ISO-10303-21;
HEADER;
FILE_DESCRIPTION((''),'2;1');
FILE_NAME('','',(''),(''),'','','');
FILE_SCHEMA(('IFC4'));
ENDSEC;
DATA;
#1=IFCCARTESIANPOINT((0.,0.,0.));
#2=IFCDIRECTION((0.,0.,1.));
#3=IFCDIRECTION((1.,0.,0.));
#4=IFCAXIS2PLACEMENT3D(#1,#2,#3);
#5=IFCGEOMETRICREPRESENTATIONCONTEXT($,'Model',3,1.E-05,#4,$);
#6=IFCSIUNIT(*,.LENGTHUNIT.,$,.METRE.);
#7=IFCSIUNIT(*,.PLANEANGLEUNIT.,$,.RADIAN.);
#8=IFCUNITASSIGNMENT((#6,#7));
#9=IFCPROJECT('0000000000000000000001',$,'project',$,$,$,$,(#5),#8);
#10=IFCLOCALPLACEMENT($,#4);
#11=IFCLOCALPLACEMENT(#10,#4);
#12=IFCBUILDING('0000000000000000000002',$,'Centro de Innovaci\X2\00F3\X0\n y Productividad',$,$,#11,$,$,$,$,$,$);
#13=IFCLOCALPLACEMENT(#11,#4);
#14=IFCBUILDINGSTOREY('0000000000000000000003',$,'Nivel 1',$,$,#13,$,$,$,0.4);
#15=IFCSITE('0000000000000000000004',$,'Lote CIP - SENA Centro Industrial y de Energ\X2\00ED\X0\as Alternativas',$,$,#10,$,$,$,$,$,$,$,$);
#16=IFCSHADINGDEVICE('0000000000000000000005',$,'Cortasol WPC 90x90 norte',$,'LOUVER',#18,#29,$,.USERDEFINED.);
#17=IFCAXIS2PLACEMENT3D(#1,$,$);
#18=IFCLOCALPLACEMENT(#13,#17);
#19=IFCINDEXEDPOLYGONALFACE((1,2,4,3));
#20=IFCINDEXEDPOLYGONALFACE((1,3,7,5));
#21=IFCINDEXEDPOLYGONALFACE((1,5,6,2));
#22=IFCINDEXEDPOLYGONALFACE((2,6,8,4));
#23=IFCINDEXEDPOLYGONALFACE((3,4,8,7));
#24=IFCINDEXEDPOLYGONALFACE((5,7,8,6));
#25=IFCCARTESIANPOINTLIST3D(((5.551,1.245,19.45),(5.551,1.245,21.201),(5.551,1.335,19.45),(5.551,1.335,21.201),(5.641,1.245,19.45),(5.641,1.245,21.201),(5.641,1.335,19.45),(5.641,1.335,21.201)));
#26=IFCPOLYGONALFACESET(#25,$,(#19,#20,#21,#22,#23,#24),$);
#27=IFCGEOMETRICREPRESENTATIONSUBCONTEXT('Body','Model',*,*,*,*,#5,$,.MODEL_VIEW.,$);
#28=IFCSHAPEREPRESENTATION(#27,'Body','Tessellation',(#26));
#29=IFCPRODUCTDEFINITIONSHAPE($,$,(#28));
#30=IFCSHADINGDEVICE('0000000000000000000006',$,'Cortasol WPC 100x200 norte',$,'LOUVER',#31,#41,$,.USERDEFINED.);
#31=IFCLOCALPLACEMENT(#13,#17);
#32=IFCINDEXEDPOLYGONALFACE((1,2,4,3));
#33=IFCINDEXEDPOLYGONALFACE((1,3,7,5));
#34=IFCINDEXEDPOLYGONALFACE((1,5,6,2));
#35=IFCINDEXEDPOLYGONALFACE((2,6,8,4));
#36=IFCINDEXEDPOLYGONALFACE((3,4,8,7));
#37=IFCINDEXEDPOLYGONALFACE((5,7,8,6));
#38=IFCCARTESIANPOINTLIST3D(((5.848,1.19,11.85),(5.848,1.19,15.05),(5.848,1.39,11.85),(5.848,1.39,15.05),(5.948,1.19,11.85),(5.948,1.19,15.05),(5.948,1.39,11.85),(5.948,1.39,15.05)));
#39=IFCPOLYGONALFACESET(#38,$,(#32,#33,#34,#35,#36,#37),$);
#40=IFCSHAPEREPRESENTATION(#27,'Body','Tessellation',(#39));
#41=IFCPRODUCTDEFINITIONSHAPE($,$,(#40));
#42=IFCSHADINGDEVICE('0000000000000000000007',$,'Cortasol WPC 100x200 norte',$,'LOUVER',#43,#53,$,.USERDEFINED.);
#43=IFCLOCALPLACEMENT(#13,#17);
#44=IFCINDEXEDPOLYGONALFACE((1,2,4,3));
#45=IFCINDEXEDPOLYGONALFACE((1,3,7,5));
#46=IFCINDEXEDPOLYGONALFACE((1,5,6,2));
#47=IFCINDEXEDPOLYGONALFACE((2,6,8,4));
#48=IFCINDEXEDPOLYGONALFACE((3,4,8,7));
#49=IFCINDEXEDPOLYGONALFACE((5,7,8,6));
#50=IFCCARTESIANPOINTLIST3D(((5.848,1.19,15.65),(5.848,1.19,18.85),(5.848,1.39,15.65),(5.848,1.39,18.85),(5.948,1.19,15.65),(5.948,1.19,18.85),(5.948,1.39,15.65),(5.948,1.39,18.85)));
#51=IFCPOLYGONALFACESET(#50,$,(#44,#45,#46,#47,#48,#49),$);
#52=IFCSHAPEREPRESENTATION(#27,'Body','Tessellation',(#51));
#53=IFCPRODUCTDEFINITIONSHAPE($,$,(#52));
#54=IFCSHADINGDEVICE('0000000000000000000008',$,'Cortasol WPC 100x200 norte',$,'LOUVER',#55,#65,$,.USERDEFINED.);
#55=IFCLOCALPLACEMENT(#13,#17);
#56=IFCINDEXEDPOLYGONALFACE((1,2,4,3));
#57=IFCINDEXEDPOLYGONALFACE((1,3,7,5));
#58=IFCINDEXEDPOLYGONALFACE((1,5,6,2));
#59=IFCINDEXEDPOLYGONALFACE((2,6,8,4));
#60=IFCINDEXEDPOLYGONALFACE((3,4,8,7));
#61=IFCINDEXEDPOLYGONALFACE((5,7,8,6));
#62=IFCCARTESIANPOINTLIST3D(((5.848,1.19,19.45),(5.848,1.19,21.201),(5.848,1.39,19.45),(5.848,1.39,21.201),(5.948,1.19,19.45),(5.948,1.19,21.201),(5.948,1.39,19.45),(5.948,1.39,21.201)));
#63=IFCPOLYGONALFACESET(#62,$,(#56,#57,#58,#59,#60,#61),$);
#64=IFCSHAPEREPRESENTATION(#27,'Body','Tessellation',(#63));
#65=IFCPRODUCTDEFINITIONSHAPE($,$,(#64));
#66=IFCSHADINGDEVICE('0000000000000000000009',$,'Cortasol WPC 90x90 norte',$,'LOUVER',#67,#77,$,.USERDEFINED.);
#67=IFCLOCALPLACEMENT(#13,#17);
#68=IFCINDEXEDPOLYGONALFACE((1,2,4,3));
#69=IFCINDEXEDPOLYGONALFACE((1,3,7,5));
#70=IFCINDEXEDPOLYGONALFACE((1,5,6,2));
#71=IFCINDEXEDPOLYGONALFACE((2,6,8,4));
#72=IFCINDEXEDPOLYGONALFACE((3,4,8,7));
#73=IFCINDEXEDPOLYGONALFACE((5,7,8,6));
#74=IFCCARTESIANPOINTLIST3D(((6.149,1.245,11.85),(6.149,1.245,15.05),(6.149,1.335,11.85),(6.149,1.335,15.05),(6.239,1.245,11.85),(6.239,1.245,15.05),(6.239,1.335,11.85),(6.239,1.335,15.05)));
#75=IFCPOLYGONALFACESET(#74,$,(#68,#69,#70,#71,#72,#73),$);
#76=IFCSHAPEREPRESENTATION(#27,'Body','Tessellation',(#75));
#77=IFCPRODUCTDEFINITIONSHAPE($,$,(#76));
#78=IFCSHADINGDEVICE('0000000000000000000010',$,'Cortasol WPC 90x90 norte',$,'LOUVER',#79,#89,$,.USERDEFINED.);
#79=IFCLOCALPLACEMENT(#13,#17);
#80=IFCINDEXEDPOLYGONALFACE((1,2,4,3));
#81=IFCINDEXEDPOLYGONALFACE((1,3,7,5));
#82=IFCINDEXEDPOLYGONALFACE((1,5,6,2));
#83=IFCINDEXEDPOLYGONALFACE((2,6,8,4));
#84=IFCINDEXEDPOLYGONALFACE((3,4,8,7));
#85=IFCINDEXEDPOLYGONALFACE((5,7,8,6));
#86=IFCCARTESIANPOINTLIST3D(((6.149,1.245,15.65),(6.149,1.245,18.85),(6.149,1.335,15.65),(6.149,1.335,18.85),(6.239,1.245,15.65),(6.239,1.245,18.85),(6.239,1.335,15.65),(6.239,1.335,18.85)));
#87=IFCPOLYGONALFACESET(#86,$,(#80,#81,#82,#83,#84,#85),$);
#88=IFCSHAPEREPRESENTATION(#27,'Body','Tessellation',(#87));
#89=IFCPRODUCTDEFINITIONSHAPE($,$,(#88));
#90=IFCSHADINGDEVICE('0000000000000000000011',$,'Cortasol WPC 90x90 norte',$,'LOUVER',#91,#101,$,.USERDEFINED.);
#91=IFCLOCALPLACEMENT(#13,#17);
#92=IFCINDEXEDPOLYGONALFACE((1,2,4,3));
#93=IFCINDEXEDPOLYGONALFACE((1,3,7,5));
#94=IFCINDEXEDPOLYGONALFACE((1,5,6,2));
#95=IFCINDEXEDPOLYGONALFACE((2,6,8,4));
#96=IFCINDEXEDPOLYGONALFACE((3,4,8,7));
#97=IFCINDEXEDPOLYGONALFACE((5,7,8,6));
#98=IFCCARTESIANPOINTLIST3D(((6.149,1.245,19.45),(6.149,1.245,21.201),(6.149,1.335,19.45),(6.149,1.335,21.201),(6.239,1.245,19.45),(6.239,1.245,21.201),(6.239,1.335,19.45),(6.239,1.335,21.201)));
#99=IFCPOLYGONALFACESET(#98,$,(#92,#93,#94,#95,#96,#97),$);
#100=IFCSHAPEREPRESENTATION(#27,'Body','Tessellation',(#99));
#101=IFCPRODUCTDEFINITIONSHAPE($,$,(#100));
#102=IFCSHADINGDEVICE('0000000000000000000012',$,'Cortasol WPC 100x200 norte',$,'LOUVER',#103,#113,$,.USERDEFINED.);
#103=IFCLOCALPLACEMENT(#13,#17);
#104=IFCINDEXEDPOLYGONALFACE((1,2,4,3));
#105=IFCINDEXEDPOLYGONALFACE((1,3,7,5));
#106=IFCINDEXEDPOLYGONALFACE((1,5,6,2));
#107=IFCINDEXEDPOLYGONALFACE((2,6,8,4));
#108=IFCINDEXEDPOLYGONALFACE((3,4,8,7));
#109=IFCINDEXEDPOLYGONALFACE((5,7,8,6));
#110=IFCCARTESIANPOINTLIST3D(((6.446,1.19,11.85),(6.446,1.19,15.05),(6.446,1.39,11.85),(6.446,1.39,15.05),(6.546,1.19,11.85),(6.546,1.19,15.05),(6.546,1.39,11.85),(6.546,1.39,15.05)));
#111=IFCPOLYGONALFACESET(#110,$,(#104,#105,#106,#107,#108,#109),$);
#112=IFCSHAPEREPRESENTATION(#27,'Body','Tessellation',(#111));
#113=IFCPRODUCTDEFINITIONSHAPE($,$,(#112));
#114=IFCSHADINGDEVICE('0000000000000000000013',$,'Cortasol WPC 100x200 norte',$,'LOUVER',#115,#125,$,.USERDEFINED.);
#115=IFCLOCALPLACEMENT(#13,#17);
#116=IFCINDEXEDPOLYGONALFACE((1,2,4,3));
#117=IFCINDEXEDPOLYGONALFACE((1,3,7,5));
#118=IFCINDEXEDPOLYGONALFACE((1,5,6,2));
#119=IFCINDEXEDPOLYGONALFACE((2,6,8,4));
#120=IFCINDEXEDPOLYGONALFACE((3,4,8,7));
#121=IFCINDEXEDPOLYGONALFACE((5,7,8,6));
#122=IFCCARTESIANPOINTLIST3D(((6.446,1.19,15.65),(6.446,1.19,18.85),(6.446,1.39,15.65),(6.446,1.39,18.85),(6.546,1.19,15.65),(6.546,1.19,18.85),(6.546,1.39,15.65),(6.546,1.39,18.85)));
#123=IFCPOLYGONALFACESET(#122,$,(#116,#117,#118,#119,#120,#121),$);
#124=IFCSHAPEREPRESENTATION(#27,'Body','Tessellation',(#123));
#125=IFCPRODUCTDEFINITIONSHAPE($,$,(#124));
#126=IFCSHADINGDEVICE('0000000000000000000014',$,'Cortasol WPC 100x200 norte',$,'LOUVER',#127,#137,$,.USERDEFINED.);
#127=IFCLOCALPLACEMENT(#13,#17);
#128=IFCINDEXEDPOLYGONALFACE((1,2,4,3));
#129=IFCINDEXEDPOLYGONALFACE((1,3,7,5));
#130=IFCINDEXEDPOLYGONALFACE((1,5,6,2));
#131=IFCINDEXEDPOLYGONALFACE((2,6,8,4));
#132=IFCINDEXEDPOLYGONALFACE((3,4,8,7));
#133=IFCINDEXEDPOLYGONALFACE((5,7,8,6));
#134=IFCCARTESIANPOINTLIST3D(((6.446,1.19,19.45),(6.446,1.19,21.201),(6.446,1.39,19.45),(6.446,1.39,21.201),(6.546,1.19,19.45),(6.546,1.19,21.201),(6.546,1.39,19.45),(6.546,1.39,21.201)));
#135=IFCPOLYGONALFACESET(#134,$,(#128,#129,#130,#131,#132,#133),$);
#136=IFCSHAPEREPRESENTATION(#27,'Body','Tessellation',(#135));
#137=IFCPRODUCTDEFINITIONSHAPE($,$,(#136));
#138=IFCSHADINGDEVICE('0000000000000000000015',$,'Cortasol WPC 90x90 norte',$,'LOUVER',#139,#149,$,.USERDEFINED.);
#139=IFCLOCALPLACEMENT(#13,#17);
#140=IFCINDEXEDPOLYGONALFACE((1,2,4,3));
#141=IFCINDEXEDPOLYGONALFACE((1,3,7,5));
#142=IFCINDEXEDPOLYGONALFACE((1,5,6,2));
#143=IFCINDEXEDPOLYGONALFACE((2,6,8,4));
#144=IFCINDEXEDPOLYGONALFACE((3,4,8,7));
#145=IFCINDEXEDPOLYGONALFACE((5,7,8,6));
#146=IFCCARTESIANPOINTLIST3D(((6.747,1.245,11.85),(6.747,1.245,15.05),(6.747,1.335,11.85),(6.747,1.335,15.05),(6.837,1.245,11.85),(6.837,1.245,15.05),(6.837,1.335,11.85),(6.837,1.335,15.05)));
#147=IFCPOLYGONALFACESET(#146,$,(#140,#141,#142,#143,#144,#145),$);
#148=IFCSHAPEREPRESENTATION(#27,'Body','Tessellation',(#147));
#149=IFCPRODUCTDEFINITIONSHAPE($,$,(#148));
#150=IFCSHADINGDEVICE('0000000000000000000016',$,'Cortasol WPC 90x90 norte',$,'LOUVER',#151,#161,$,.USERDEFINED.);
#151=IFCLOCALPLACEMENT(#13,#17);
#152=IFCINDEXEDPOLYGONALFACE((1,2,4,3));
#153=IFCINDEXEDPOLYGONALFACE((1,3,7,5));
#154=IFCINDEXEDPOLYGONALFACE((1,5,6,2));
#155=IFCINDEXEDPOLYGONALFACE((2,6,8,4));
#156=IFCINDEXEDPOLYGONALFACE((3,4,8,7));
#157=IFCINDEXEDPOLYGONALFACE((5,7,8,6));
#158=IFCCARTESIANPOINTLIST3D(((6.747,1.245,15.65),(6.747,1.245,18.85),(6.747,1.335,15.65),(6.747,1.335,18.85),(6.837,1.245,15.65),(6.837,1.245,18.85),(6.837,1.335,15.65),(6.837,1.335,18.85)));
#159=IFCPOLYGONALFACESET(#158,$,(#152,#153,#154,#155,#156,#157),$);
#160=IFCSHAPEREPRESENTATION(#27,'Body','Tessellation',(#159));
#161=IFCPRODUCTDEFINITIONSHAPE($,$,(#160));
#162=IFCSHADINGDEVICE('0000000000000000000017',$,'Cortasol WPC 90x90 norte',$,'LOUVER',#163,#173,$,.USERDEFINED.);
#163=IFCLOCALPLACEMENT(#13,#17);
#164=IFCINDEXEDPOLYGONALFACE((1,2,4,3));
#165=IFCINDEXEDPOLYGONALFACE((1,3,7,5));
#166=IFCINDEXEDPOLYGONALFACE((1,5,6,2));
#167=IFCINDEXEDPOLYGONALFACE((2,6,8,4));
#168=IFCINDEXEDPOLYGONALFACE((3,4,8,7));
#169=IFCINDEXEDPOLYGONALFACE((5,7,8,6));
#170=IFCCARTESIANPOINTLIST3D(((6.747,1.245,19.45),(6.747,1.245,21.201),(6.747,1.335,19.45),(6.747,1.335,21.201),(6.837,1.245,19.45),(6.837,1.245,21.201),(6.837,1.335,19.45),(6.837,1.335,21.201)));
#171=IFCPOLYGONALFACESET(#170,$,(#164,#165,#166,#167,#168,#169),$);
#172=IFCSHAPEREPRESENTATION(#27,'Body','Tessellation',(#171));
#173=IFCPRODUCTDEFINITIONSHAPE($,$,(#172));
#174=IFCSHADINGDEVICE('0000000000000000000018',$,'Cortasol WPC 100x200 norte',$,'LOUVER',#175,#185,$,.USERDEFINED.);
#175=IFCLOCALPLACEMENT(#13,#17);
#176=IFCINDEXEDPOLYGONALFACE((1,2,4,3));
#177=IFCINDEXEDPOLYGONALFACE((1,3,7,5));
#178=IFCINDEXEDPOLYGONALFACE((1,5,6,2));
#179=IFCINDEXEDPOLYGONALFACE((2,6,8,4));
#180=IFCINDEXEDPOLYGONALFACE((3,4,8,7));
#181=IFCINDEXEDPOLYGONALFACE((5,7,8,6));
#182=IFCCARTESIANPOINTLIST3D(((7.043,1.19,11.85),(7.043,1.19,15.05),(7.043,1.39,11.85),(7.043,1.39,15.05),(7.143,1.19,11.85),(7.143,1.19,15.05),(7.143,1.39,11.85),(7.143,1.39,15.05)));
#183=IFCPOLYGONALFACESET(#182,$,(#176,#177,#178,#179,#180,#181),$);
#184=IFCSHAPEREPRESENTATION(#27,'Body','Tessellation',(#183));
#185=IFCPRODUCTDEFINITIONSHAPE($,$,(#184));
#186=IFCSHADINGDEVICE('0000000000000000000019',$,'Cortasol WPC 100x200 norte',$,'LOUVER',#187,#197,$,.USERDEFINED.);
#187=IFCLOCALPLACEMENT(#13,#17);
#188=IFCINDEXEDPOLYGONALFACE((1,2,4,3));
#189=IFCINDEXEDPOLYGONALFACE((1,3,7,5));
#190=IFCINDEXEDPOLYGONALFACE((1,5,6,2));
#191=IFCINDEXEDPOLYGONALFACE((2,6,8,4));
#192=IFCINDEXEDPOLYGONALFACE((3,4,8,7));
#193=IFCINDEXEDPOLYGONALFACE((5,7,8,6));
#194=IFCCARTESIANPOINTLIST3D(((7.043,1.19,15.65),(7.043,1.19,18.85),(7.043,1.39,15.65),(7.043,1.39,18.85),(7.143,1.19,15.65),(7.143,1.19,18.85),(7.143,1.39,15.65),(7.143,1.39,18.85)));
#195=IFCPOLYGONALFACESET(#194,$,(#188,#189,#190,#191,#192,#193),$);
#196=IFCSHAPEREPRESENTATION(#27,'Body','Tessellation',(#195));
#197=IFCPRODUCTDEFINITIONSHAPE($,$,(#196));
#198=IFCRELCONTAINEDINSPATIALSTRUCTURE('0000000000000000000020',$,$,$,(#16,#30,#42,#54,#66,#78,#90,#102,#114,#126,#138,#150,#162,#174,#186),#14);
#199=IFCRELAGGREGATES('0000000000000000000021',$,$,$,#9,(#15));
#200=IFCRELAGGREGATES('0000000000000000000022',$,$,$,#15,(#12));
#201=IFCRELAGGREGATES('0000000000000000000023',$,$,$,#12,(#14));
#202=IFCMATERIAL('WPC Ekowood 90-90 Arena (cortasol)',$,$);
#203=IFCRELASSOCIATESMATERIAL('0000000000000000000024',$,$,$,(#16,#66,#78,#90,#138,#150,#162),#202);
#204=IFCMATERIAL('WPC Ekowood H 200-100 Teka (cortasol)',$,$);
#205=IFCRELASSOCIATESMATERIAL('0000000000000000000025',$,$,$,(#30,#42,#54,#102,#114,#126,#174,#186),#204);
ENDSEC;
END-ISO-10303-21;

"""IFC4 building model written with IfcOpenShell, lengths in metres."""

from ifc_helpers import new_model, si_unit, frame, origin_with_axes, place, context, subcontext, project, spatial, polyline, outline, extrude, material, element, save


model = new_model("IFC4")

# Units and contexts
model_context = context("Model", 3, precision=1e-05, world=origin_with_axes())
body_context = subcontext(model_context, "Body", "Model", "MODEL_VIEW")
ifc_project = project(units=[si_unit("LENGTHUNIT", "METRE"), si_unit("PLANEANGLEUNIT", "RADIAN")], contexts=[model_context])

# Site, building, storey
site_placement = place(None, origin_with_axes())
site = spatial("IfcSite", under=ifc_project, at=site_placement, Name="Lote CIP - SENA Centro Industrial y de Energías Alternativas")
building_placement = place(site_placement, origin_with_axes())
building = spatial("IfcBuilding", under=site, at=building_placement, Name="Centro de Innovación y Productividad")
storey_placement = place(building_placement, origin_with_axes())
storey = spatial("IfcBuildingStorey", under=building, at=storey_placement, Name="Nivel 1", Elevation=0.4)

# Shading devices
ifc_material_1 = material(Name="WPC Ekowood 90-90 Arena (cortasol)")
shading_device_1_placement = place(storey_placement, origin_with_axes())
element("IfcShadingDevice", 1, at=shading_device_1_placement, inside=storey, material=ifc_material_1, Name="Cortasol WPC 90x90 norte", ObjectType="LOUVER", PredefinedType="USERDEFINED", context=body_context, shape_type="SweptSolid", body=[
    extrude(outline(polyline([(5.551, 1.245), (5.551, 1.335), (5.641, 1.335), (5.641, 1.245), (5.551, 1.245)])), frame((0.0, 0.0, 19.45)), (0.0, 0.0, 1.0), 1.751),
])
ifc_material_2 = material(Name="WPC Ekowood H 200-100 Teka (cortasol)")
shading_device_2_placement = place(storey_placement, origin_with_axes())
element("IfcShadingDevice", 2, at=shading_device_2_placement, inside=storey, material=ifc_material_2, Name="Cortasol WPC 100x200 norte", ObjectType="LOUVER", PredefinedType="USERDEFINED", context=body_context, shape_type="SweptSolid", body=[
    extrude(outline(polyline([(5.848, 1.19), (5.848, 1.39), (5.948, 1.39), (5.948, 1.19), (5.848, 1.19)])), frame((0.0, 0.0, 11.85)), (0.0, 0.0, 1.0), 3.2),
])
shading_device_3_placement = place(storey_placement, origin_with_axes())
element("IfcShadingDevice", 3, at=shading_device_3_placement, inside=storey, material=ifc_material_2, Name="Cortasol WPC 100x200 norte", ObjectType="LOUVER", PredefinedType="USERDEFINED", context=body_context, shape_type="SweptSolid", body=[
    extrude(outline(polyline([(5.848, 1.19), (5.848, 1.39), (5.948, 1.39), (5.948, 1.19), (5.848, 1.19)])), frame((0.0, 0.0, 15.65)), (0.0, 0.0, 1.0), 3.2),
])
shading_device_4_placement = place(storey_placement, origin_with_axes())
element("IfcShadingDevice", 4, at=shading_device_4_placement, inside=storey, material=ifc_material_2, Name="Cortasol WPC 100x200 norte", ObjectType="LOUVER", PredefinedType="USERDEFINED", context=body_context, shape_type="SweptSolid", body=[
    extrude(outline(polyline([(5.848, 1.19), (5.848, 1.39), (5.948, 1.39), (5.948, 1.19), (5.848, 1.19)])), frame((0.0, 0.0, 19.45)), (0.0, 0.0, 1.0), 1.751),
])
shading_device_5_placement = place(storey_placement, origin_with_axes())
element("IfcShadingDevice", 5, at=shading_device_5_placement, inside=storey, material=ifc_material_1, Name="Cortasol WPC 90x90 norte", ObjectType="LOUVER", PredefinedType="USERDEFINED", context=body_context, shape_type="SweptSolid", body=[
    extrude(outline(polyline([(6.149, 1.245), (6.149, 1.335), (6.239, 1.335), (6.239, 1.245), (6.149, 1.245)])), frame((0.0, 0.0, 11.85)), (0.0, 0.0, 1.0), 3.2),
])
shading_device_6_placement = place(storey_placement, origin_with_axes())
element("IfcShadingDevice", 6, at=shading_device_6_placement, inside=storey, material=ifc_material_1, Name="Cortasol WPC 90x90 norte", ObjectType="LOUVER", PredefinedType="USERDEFINED", context=body_context, shape_type="SweptSolid", body=[
    extrude(outline(polyline([(6.149, 1.245), (6.149, 1.335), (6.239, 1.335), (6.239, 1.245), (6.149, 1.245)])), frame((0.0, 0.0, 15.65)), (0.0, 0.0, 1.0), 3.2),
])
shading_device_7_placement = place(storey_placement, origin_with_axes())
element("IfcShadingDevice", 7, at=shading_device_7_placement, inside=storey, material=ifc_material_1, Name="Cortasol WPC 90x90 norte", ObjectType="LOUVER", PredefinedType="USERDEFINED", context=body_context, shape_type="SweptSolid", body=[
    extrude(outline(polyline([(6.149, 1.245), (6.149, 1.335), (6.239, 1.335), (6.239, 1.245), (6.149, 1.245)])), frame((0.0, 0.0, 19.45)), (0.0, 0.0, 1.0), 1.751),
])
shading_device_8_placement = place(storey_placement, origin_with_axes())
element("IfcShadingDevice", 8, at=shading_device_8_placement, inside=storey, material=ifc_material_2, Name="Cortasol WPC 100x200 norte", ObjectType="LOUVER", PredefinedType="USERDEFINED", context=body_context, shape_type="SweptSolid", body=[
    extrude(outline(polyline([(6.446, 1.19), (6.446, 1.39), (6.546, 1.39), (6.546, 1.19), (6.446, 1.19)])), frame((0.0, 0.0, 11.85)), (0.0, 0.0, 1.0), 3.2),
])
shading_device_9_placement = place(storey_placement, origin_with_axes())
element("IfcShadingDevice", 9, at=shading_device_9_placement, inside=storey, material=ifc_material_2, Name="Cortasol WPC 100x200 norte", ObjectType="LOUVER", PredefinedType="USERDEFINED", context=body_context, shape_type="SweptSolid", body=[
    extrude(outline(polyline([(6.446, 1.19), (6.446, 1.39), (6.546, 1.39), (6.546, 1.19), (6.446, 1.19)])), frame((0.0, 0.0, 15.65)), (0.0, 0.0, 1.0), 3.2),
])
shading_device_10_placement = place(storey_placement, origin_with_axes())
element("IfcShadingDevice", 10, at=shading_device_10_placement, inside=storey, material=ifc_material_2, Name="Cortasol WPC 100x200 norte", ObjectType="LOUVER", PredefinedType="USERDEFINED", context=body_context, shape_type="SweptSolid", body=[
    extrude(outline(polyline([(6.446, 1.19), (6.446, 1.39), (6.546, 1.39), (6.546, 1.19), (6.446, 1.19)])), frame((0.0, 0.0, 19.45)), (0.0, 0.0, 1.0), 1.751),
])
shading_device_11_placement = place(storey_placement, origin_with_axes())
element("IfcShadingDevice", 11, at=shading_device_11_placement, inside=storey, material=ifc_material_1, Name="Cortasol WPC 90x90 norte", ObjectType="LOUVER", PredefinedType="USERDEFINED", context=body_context, shape_type="SweptSolid", body=[
    extrude(outline(polyline([(6.747, 1.245), (6.747, 1.335), (6.837, 1.335), (6.837, 1.245), (6.747, 1.245)])), frame((0.0, 0.0, 11.85)), (0.0, 0.0, 1.0), 3.2),
])
shading_device_12_placement = place(storey_placement, origin_with_axes())
element("IfcShadingDevice", 12, at=shading_device_12_placement, inside=storey, material=ifc_material_1, Name="Cortasol WPC 90x90 norte", ObjectType="LOUVER", PredefinedType="USERDEFINED", context=body_context, shape_type="SweptSolid", body=[
    extrude(outline(polyline([(6.747, 1.245), (6.747, 1.335), (6.837, 1.335), (6.837, 1.245), (6.747, 1.245)])), frame((0.0, 0.0, 15.65)), (0.0, 0.0, 1.0), 3.2),
])
shading_device_13_placement = place(storey_placement, origin_with_axes())
element("IfcShadingDevice", 13, at=shading_device_13_placement, inside=storey, material=ifc_material_1, Name="Cortasol WPC 90x90 norte", ObjectType="LOUVER", PredefinedType="USERDEFINED", context=body_context, shape_type="SweptSolid", body=[
    extrude(outline(polyline([(6.747, 1.245), (6.747, 1.335), (6.837, 1.335), (6.837, 1.245), (6.747, 1.245)])), frame((0.0, 0.0, 19.45)), (0.0, 0.0, 1.0), 1.751),
])
shading_device_14_placement = place(storey_placement, origin_with_axes())
element("IfcShadingDevice", 14, at=shading_device_14_placement, inside=storey, material=ifc_material_2, Name="Cortasol WPC 100x200 norte", ObjectType="LOUVER", PredefinedType="USERDEFINED", context=body_context, shape_type="SweptSolid", body=[
    extrude(outline(polyline([(7.043, 1.19), (7.043, 1.39), (7.143, 1.39), (7.143, 1.19), (7.043, 1.19)])), frame((0.0, 0.0, 11.85)), (0.0, 0.0, 1.0), 3.2),
])
shading_device_15_placement = place(storey_placement, origin_with_axes())
element("IfcShadingDevice", 15, at=shading_device_15_placement, inside=storey, material=ifc_material_2, Name="Cortasol WPC 100x200 norte", ObjectType="LOUVER", PredefinedType="USERDEFINED", context=body_context, shape_type="SweptSolid", body=[
    extrude(outline(polyline([(7.043, 1.19), (7.043, 1.39), (7.143, 1.39), (7.143, 1.19), (7.043, 1.19)])), frame((0.0, 0.0, 15.65)), (0.0, 0.0, 1.0), 3.2),
])

save(model, "model.ifc")
